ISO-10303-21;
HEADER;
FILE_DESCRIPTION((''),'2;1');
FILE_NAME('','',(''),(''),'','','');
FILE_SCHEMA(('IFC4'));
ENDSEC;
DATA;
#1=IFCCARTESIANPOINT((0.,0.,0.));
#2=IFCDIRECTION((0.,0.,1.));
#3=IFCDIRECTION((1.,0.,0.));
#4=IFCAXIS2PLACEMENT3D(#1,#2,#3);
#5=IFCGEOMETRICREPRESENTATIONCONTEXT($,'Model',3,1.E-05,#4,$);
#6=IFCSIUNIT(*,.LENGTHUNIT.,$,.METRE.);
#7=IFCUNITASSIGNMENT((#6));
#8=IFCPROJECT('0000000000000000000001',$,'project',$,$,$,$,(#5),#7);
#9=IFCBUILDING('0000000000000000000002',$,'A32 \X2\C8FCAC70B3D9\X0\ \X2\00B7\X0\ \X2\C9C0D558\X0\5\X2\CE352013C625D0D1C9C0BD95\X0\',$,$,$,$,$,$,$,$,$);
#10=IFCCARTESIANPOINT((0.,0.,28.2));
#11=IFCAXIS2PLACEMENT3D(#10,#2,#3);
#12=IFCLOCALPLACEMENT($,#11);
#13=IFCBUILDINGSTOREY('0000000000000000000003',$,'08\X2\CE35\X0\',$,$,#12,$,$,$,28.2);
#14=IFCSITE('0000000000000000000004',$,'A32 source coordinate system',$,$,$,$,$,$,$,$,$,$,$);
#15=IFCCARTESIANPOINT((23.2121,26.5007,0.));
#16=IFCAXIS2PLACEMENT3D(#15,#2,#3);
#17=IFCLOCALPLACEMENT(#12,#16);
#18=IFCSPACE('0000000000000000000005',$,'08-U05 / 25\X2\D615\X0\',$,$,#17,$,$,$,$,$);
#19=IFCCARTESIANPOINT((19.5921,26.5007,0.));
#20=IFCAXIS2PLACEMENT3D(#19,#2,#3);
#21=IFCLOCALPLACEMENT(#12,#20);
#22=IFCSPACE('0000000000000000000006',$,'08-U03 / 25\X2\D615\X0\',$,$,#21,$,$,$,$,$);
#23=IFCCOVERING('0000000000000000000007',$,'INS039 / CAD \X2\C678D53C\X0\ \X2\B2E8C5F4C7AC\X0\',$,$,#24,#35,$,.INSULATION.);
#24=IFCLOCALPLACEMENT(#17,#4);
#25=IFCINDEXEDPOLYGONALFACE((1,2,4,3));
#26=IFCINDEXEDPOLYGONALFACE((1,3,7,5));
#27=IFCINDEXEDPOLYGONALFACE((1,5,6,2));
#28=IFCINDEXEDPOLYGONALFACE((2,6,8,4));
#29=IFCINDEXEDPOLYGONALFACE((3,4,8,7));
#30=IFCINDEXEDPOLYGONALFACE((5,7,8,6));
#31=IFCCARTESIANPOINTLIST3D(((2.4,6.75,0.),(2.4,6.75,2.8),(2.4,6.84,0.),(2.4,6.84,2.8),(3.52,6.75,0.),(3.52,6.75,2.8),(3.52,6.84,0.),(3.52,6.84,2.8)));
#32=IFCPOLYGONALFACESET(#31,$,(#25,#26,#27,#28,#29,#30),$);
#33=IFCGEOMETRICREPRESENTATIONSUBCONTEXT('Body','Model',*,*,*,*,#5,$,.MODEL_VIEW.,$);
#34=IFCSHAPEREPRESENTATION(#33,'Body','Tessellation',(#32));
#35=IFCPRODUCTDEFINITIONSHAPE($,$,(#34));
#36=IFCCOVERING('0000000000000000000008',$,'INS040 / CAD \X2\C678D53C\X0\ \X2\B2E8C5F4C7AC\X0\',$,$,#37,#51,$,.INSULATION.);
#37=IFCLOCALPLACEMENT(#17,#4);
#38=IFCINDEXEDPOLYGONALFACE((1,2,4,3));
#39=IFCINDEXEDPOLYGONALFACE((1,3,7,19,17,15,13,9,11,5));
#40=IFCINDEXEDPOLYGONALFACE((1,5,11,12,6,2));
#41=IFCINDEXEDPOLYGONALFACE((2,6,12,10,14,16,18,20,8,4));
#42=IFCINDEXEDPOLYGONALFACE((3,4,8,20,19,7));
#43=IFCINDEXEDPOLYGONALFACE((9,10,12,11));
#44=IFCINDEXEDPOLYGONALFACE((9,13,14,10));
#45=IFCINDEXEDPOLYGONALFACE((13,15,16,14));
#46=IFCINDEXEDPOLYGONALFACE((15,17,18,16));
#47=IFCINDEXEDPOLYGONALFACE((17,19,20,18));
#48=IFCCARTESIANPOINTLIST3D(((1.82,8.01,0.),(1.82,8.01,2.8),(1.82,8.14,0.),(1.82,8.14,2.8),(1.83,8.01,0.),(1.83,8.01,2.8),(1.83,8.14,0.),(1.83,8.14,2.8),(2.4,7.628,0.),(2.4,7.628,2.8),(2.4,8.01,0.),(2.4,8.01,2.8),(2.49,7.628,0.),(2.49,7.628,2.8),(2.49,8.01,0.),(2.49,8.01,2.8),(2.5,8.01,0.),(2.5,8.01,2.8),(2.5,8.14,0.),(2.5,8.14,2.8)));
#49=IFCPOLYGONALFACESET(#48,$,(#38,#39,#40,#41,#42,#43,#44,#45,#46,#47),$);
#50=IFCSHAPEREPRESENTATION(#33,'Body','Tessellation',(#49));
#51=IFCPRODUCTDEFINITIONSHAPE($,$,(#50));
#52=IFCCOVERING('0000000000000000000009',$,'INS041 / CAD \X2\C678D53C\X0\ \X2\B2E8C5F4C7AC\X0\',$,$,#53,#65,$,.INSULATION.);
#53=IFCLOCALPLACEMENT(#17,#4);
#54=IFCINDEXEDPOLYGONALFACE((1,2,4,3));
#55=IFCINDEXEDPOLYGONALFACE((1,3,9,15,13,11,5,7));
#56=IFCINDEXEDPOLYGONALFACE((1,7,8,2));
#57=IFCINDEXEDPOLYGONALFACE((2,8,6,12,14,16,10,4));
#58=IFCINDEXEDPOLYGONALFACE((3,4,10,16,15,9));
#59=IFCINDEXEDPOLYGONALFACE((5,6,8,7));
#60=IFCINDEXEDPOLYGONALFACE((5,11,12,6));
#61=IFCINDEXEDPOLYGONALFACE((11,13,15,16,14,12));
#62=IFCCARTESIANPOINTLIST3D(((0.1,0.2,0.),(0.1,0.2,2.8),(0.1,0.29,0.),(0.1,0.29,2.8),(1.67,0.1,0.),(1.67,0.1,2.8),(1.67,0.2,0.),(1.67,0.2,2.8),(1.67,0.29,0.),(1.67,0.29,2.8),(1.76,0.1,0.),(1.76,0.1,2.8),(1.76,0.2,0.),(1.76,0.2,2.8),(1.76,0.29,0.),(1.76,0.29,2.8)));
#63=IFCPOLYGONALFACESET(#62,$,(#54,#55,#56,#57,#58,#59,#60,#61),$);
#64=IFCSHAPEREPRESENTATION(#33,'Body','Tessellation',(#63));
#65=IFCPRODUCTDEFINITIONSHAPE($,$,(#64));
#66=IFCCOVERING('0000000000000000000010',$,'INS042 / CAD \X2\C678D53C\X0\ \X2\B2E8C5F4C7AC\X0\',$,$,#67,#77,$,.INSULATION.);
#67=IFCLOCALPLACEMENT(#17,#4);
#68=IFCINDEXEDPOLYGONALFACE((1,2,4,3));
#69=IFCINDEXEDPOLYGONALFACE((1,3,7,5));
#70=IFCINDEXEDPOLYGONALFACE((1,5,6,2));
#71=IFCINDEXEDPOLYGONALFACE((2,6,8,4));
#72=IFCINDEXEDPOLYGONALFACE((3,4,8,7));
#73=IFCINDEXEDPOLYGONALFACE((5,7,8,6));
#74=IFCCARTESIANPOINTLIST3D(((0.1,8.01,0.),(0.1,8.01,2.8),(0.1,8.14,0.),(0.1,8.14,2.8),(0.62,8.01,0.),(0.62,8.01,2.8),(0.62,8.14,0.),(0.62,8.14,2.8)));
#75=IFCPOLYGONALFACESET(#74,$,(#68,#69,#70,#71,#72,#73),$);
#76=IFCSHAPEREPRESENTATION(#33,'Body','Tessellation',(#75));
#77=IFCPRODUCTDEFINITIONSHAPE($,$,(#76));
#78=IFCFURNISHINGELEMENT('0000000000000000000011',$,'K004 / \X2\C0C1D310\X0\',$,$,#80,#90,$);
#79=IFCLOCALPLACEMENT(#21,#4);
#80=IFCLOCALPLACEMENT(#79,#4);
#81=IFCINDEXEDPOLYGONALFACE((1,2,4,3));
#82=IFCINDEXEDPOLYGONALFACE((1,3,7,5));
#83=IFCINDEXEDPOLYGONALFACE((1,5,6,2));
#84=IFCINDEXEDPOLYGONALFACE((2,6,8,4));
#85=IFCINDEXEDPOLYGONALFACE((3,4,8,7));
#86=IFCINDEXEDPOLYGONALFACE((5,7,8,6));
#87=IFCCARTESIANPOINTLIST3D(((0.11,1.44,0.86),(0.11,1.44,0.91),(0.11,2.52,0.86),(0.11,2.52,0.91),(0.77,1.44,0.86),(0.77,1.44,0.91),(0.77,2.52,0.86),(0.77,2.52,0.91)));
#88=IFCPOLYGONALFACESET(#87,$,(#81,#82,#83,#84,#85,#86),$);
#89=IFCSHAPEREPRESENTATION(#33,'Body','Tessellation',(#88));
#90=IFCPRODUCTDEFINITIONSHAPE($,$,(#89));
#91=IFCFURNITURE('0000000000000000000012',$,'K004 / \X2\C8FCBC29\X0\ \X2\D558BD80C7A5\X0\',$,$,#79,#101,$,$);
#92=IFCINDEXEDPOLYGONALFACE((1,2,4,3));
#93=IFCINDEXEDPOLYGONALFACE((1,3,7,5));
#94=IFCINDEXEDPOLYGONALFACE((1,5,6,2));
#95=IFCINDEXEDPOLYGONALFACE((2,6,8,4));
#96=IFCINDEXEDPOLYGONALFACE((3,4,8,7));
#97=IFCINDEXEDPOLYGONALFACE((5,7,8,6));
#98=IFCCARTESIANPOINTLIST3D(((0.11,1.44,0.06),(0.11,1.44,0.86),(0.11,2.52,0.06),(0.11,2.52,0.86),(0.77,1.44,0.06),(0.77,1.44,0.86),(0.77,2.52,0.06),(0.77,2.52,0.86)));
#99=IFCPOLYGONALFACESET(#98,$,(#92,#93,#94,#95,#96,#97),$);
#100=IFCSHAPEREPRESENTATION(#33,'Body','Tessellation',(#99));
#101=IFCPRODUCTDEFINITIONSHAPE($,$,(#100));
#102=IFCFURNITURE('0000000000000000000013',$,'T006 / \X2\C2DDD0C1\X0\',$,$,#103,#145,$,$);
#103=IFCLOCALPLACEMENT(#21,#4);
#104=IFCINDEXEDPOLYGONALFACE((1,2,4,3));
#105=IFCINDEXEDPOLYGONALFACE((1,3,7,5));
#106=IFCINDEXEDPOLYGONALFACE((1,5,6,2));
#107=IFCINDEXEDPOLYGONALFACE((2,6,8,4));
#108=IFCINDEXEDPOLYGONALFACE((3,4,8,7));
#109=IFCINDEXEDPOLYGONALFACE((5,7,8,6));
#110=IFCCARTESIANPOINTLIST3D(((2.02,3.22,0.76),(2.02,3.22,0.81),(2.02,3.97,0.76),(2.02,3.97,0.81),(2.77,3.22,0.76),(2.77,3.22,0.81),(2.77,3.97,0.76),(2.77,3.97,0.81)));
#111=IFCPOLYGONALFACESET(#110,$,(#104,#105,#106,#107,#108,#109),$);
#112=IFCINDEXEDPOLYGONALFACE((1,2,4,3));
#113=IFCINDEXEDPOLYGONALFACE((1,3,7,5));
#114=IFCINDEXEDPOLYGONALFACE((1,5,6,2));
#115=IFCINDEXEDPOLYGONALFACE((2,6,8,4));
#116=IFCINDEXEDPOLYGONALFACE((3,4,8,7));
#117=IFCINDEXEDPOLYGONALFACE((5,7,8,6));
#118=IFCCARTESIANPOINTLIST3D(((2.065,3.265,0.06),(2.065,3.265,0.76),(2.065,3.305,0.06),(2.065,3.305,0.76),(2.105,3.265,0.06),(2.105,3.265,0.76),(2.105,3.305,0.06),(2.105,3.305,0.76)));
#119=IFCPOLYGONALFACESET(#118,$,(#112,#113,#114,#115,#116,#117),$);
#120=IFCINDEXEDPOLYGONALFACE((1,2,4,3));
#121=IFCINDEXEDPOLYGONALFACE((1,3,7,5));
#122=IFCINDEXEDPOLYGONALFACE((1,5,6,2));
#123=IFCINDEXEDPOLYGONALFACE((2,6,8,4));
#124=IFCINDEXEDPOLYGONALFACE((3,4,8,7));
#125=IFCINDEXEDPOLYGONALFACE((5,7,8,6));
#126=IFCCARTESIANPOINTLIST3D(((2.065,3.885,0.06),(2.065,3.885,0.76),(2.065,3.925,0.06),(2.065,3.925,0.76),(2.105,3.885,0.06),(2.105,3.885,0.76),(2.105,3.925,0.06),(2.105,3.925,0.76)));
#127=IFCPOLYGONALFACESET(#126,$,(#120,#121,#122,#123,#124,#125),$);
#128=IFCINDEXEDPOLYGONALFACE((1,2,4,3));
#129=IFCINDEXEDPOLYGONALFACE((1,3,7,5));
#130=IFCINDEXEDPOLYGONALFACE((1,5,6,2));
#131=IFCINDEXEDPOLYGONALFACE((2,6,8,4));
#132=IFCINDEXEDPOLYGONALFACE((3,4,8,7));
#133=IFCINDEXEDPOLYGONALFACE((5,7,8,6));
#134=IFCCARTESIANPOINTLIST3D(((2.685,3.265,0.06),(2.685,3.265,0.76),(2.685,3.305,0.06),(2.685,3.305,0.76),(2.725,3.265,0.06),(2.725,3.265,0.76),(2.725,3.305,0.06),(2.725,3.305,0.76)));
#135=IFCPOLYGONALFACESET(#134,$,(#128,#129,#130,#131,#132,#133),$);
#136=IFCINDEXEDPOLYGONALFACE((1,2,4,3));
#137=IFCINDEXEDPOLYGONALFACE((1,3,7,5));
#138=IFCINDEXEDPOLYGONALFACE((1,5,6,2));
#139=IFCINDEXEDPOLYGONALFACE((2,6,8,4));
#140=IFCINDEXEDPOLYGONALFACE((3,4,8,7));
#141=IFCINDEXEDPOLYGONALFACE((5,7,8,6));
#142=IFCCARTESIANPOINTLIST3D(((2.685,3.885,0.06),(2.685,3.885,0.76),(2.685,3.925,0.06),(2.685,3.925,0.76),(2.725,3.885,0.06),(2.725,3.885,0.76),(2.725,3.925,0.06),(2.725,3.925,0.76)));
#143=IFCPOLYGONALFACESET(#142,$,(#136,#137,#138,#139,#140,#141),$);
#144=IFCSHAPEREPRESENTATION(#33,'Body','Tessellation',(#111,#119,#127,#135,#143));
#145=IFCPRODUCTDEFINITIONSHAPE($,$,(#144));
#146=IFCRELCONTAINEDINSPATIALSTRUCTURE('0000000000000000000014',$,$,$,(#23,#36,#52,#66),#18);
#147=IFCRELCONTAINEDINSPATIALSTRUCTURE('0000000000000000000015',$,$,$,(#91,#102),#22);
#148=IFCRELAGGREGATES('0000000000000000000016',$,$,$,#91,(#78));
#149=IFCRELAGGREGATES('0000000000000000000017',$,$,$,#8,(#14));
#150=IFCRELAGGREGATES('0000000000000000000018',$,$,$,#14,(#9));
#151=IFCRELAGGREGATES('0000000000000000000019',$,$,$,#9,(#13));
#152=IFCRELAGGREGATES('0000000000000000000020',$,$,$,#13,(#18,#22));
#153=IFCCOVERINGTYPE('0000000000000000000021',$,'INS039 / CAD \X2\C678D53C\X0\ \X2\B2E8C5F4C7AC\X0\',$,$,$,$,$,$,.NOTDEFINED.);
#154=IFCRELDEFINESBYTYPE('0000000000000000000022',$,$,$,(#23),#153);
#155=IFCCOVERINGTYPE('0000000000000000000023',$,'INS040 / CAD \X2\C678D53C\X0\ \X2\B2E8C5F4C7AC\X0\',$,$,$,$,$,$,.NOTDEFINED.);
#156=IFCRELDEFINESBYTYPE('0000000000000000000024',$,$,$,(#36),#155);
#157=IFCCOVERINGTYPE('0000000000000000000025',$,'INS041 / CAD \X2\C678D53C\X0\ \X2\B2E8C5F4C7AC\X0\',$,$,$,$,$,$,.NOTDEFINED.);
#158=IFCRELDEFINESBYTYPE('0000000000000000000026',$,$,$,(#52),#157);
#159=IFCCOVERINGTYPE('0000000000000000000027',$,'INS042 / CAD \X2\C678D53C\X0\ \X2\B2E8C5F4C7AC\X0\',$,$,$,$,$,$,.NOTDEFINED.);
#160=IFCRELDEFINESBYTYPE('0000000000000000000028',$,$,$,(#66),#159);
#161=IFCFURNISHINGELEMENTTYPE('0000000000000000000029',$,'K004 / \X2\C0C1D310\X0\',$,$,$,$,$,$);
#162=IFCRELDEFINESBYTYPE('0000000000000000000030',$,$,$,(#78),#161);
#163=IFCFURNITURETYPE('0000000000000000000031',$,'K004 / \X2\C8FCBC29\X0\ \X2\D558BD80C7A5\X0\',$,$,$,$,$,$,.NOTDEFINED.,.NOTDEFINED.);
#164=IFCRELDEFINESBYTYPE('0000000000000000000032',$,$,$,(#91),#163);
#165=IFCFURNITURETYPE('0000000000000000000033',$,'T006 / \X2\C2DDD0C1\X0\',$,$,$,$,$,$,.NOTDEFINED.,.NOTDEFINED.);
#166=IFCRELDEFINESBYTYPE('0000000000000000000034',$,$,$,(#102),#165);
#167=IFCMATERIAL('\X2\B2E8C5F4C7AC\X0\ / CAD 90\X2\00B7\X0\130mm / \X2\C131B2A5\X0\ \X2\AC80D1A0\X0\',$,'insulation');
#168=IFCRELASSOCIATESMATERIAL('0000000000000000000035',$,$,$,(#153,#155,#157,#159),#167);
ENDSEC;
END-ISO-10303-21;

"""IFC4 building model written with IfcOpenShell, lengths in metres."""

from ifc_helpers import new_model, si_unit, frame, origin, origin_with_axes, place, context, subcontext, project, spatial, polyline, outline, extrude, source, transform, mapped, material, type_object, type_shapes, element, aggregate, save


model = new_model("IFC4")

# Units and contexts
model_context = context("Model", 3, precision=1e-05, world=origin_with_axes())
body_context = subcontext(model_context, "Body", "Model", "MODEL_VIEW")
ifc_project = project(units=[si_unit("LENGTHUNIT", "METRE")], contexts=[model_context])

# Site, building, storey, space
storey_placement = place(None, frame((0.0, 0.0, 28.2), z_axis=(0.0, 0.0, 1.0), x_axis=(1.0, 0.0, 0.0)))
space_1_placement = place(storey_placement, frame((23.2121, 26.5007, 0.0), z_axis=(0.0, 0.0, 1.0), x_axis=(1.0, 0.0, 0.0)))
site = spatial("IfcSite", under=ifc_project, Name="A32 source coordinate system")
building = spatial("IfcBuilding", under=site, Name="A32 주거동 · 지하5층–옥탑지붕")
storey = spatial("IfcBuildingStorey", under=building, at=storey_placement, Name="08층", Elevation=28.2)
space_1 = spatial("IfcSpace", under=storey, at=space_1_placement, Name="08-U05 / 25형")

# Shared definitions
space_2_placement = place(storey_placement, frame((19.5921, 26.5007, 0.0), z_axis=(0.0, 0.0, 1.0), x_axis=(1.0, 0.0, 0.0)))
space_2 = spatial("IfcSpace", under=storey, at=space_2_placement, Name="08-U03 / 25형")

# Coverings
ifc_material = material(Name="단열재 / CAD 90·130mm / 성능 검토", Category="insulation")
covering_type_1 = type_object("IfcCoveringType", Name="INS039 / CAD 외피 단열재", PredefinedType="NOTDEFINED", material=ifc_material)
shared_shape_1 = source(origin(), body_context, "Body", "SweptSolid", [
    extrude(outline(polyline([(2.4, 6.75), (2.4, 6.84), (3.52, 6.84), (3.52, 6.75), (2.4, 6.75)])), origin(), (0.0, 0.0, 1.0), 2.8),
])
type_shapes(covering_type_1, [shared_shape_1])
covering_1_placement = place(space_1_placement, origin_with_axes())
element("IfcCovering", 1, at=covering_1_placement, inside=space_1, type_object=covering_type_1, Name="INS039 / CAD 외피 단열재", PredefinedType="INSULATION", context=body_context, shape_type="MappedRepresentation", body=[
    mapped(shared_shape_1, transform((0.0, 0.0, 0.0), scale=1.0)),
])
covering_type_2 = type_object("IfcCoveringType", Name="INS040 / CAD 외피 단열재", PredefinedType="NOTDEFINED", material=ifc_material)
shared_shape_2 = source(origin(), body_context, "Body", "SweptSolid", [
    extrude(outline(polyline([(2.4, 7.628), (2.4, 8.01), (1.83, 8.01), (1.82, 8.01), (1.82, 8.14), (1.83, 8.14), (2.5, 8.14), (2.5, 8.01), (2.49, 8.01), (2.49, 7.628), (2.4, 7.628)])), origin(), (0.0, 0.0, 1.0), 2.8),
])
type_shapes(covering_type_2, [shared_shape_2])
covering_2_placement = place(space_1_placement, origin_with_axes())
element("IfcCovering", 2, at=covering_2_placement, inside=space_1, type_object=covering_type_2, Name="INS040 / CAD 외피 단열재", PredefinedType="INSULATION", context=body_context, shape_type="MappedRepresentation", body=[
    mapped(shared_shape_2, transform((0.0, 0.0, 0.0), scale=1.0)),
])
covering_type_3 = type_object("IfcCoveringType", Name="INS041 / CAD 외피 단열재", PredefinedType="NOTDEFINED", material=ifc_material)
shared_shape_3 = source(origin(), body_context, "Body", "SweptSolid", [
    extrude(outline(polyline([(1.67, 0.2), (0.1, 0.2), (0.1, 0.29), (1.67, 0.29), (1.76, 0.29), (1.76, 0.2), (1.76, 0.1), (1.67, 0.1), (1.67, 0.2)])), origin(), (0.0, 0.0, 1.0), 2.8),
])
type_shapes(covering_type_3, [shared_shape_3])
covering_3_placement = place(space_1_placement, origin_with_axes())
element("IfcCovering", 3, at=covering_3_placement, inside=space_1, type_object=covering_type_3, Name="INS041 / CAD 외피 단열재", PredefinedType="INSULATION", context=body_context, shape_type="MappedRepresentation", body=[
    mapped(shared_shape_3, transform((0.0, 0.0, 0.0), scale=1.0)),
])
covering_type_4 = type_object("IfcCoveringType", Name="INS042 / CAD 외피 단열재", PredefinedType="NOTDEFINED", material=ifc_material)
shared_shape_4 = source(origin(), body_context, "Body", "SweptSolid", [
    extrude(outline(polyline([(0.62, 8.14), (0.62, 8.01), (0.1, 8.01), (0.1, 8.14), (0.62, 8.14)])), origin(), (0.0, 0.0, 1.0), 2.8),
])
type_shapes(covering_type_4, [shared_shape_4])
covering_4_placement = place(space_1_placement, origin_with_axes())
element("IfcCovering", 4, at=covering_4_placement, inside=space_1, type_object=covering_type_4, Name="INS042 / CAD 외피 단열재", PredefinedType="INSULATION", context=body_context, shape_type="MappedRepresentation", body=[
    mapped(shared_shape_4, transform((0.0, 0.0, 0.0), scale=1.0)),
])

# Furnishing element
furnishing_element_type_1 = type_object("IfcFurnishingElementType", Name="K004 / 상판")
shared_shape_5 = source(origin(), body_context, "Body", "SweptSolid", [
    extrude(outline(polyline([(0.77, 2.52), (0.77, 1.44), (0.11, 1.44), (0.11, 2.52), (0.77, 2.52)])), frame((0.0, 0.0, 0.86)), (0.0, 0.0, 1.0), 0.05),
])
type_shapes(furnishing_element_type_1, [shared_shape_5])
furniture_1_placement = place(space_2_placement, origin_with_axes())
furnishing_1_placement = place(furniture_1_placement, origin_with_axes())
furnishing_1 = element("IfcFurnishingElement", 5, at=furnishing_1_placement, type_object=furnishing_element_type_1, Name="K004 / 상판", context=body_context, shape_type="MappedRepresentation", body=[
    mapped(shared_shape_5, transform((0.0, 0.0, 0.0), scale=1.0)),
])

# Furniture
furniture_type_1 = type_object("IfcFurnitureType", Name="K004 / 주방 하부장", AssemblyPlace="NOTDEFINED", PredefinedType="NOTDEFINED")
shared_shape_6 = source(origin(), body_context, "Body", "SweptSolid", [
    extrude(outline(polyline([(0.11, 2.52), (0.77, 2.52), (0.77, 1.44), (0.11, 1.44), (0.11, 2.52)])), frame((0.0, 0.0, 0.06)), (0.0, 0.0, 1.0), 0.8),
])
type_shapes(furniture_type_1, [shared_shape_6])
furniture_1 = element("IfcFurniture", 6, at=furniture_1_placement, inside=space_2, type_object=furniture_type_1, Name="K004 / 주방 하부장", context=body_context, shape_type="MappedRepresentation", body=[
    mapped(shared_shape_6, transform((0.0, 0.0, 0.0), scale=1.0)),
])
aggregate(furniture_1, [furnishing_1])
furniture_type_2 = type_object("IfcFurnitureType", Name="T006 / 식탁", AssemblyPlace="NOTDEFINED", PredefinedType="NOTDEFINED")
shared_shape_7 = source(origin(), body_context, "Body", "SweptSolid", [
    extrude(outline(polyline([(2.77, 3.22), (2.02, 3.22), (2.02, 3.97), (2.77, 3.97), (2.77, 3.22)])), frame((0.0, 0.0, 0.76)), (0.0, 0.0, 1.0), 0.05),
    extrude(outline(polyline([(2.065, 3.265), (2.065, 3.305), (2.105, 3.305), (2.105, 3.265), (2.065, 3.265)])), frame((0.0, 0.0, 0.06)), (0.0, 0.0, 1.0), 0.7),
    extrude(outline(polyline([(2.065, 3.885), (2.065, 3.925), (2.105, 3.925), (2.105, 3.885), (2.065, 3.885)])), frame((0.0, 0.0, 0.06)), (0.0, 0.0, 1.0), 0.7),
    extrude(outline(polyline([(2.685, 3.265), (2.685, 3.305), (2.725, 3.305), (2.725, 3.265), (2.685, 3.265)])), frame((0.0, 0.0, 0.06)), (0.0, 0.0, 1.0), 0.7),
    extrude(outline(polyline([(2.685, 3.885), (2.685, 3.925), (2.725, 3.925), (2.725, 3.885), (2.685, 3.885)])), frame((0.0, 0.0, 0.06)), (0.0, 0.0, 1.0), 0.7),
])
type_shapes(furniture_type_2, [shared_shape_7])
furniture_2_placement = place(space_2_placement, origin_with_axes())
element("IfcFurniture", 7, at=furniture_2_placement, inside=space_2, type_object=furniture_type_2, Name="T006 / 식탁", context=body_context, shape_type="MappedRepresentation", body=[
    mapped(shared_shape_7, transform((0.0, 0.0, 0.0), scale=1.0)),
])

save(model, "model.ifc")
